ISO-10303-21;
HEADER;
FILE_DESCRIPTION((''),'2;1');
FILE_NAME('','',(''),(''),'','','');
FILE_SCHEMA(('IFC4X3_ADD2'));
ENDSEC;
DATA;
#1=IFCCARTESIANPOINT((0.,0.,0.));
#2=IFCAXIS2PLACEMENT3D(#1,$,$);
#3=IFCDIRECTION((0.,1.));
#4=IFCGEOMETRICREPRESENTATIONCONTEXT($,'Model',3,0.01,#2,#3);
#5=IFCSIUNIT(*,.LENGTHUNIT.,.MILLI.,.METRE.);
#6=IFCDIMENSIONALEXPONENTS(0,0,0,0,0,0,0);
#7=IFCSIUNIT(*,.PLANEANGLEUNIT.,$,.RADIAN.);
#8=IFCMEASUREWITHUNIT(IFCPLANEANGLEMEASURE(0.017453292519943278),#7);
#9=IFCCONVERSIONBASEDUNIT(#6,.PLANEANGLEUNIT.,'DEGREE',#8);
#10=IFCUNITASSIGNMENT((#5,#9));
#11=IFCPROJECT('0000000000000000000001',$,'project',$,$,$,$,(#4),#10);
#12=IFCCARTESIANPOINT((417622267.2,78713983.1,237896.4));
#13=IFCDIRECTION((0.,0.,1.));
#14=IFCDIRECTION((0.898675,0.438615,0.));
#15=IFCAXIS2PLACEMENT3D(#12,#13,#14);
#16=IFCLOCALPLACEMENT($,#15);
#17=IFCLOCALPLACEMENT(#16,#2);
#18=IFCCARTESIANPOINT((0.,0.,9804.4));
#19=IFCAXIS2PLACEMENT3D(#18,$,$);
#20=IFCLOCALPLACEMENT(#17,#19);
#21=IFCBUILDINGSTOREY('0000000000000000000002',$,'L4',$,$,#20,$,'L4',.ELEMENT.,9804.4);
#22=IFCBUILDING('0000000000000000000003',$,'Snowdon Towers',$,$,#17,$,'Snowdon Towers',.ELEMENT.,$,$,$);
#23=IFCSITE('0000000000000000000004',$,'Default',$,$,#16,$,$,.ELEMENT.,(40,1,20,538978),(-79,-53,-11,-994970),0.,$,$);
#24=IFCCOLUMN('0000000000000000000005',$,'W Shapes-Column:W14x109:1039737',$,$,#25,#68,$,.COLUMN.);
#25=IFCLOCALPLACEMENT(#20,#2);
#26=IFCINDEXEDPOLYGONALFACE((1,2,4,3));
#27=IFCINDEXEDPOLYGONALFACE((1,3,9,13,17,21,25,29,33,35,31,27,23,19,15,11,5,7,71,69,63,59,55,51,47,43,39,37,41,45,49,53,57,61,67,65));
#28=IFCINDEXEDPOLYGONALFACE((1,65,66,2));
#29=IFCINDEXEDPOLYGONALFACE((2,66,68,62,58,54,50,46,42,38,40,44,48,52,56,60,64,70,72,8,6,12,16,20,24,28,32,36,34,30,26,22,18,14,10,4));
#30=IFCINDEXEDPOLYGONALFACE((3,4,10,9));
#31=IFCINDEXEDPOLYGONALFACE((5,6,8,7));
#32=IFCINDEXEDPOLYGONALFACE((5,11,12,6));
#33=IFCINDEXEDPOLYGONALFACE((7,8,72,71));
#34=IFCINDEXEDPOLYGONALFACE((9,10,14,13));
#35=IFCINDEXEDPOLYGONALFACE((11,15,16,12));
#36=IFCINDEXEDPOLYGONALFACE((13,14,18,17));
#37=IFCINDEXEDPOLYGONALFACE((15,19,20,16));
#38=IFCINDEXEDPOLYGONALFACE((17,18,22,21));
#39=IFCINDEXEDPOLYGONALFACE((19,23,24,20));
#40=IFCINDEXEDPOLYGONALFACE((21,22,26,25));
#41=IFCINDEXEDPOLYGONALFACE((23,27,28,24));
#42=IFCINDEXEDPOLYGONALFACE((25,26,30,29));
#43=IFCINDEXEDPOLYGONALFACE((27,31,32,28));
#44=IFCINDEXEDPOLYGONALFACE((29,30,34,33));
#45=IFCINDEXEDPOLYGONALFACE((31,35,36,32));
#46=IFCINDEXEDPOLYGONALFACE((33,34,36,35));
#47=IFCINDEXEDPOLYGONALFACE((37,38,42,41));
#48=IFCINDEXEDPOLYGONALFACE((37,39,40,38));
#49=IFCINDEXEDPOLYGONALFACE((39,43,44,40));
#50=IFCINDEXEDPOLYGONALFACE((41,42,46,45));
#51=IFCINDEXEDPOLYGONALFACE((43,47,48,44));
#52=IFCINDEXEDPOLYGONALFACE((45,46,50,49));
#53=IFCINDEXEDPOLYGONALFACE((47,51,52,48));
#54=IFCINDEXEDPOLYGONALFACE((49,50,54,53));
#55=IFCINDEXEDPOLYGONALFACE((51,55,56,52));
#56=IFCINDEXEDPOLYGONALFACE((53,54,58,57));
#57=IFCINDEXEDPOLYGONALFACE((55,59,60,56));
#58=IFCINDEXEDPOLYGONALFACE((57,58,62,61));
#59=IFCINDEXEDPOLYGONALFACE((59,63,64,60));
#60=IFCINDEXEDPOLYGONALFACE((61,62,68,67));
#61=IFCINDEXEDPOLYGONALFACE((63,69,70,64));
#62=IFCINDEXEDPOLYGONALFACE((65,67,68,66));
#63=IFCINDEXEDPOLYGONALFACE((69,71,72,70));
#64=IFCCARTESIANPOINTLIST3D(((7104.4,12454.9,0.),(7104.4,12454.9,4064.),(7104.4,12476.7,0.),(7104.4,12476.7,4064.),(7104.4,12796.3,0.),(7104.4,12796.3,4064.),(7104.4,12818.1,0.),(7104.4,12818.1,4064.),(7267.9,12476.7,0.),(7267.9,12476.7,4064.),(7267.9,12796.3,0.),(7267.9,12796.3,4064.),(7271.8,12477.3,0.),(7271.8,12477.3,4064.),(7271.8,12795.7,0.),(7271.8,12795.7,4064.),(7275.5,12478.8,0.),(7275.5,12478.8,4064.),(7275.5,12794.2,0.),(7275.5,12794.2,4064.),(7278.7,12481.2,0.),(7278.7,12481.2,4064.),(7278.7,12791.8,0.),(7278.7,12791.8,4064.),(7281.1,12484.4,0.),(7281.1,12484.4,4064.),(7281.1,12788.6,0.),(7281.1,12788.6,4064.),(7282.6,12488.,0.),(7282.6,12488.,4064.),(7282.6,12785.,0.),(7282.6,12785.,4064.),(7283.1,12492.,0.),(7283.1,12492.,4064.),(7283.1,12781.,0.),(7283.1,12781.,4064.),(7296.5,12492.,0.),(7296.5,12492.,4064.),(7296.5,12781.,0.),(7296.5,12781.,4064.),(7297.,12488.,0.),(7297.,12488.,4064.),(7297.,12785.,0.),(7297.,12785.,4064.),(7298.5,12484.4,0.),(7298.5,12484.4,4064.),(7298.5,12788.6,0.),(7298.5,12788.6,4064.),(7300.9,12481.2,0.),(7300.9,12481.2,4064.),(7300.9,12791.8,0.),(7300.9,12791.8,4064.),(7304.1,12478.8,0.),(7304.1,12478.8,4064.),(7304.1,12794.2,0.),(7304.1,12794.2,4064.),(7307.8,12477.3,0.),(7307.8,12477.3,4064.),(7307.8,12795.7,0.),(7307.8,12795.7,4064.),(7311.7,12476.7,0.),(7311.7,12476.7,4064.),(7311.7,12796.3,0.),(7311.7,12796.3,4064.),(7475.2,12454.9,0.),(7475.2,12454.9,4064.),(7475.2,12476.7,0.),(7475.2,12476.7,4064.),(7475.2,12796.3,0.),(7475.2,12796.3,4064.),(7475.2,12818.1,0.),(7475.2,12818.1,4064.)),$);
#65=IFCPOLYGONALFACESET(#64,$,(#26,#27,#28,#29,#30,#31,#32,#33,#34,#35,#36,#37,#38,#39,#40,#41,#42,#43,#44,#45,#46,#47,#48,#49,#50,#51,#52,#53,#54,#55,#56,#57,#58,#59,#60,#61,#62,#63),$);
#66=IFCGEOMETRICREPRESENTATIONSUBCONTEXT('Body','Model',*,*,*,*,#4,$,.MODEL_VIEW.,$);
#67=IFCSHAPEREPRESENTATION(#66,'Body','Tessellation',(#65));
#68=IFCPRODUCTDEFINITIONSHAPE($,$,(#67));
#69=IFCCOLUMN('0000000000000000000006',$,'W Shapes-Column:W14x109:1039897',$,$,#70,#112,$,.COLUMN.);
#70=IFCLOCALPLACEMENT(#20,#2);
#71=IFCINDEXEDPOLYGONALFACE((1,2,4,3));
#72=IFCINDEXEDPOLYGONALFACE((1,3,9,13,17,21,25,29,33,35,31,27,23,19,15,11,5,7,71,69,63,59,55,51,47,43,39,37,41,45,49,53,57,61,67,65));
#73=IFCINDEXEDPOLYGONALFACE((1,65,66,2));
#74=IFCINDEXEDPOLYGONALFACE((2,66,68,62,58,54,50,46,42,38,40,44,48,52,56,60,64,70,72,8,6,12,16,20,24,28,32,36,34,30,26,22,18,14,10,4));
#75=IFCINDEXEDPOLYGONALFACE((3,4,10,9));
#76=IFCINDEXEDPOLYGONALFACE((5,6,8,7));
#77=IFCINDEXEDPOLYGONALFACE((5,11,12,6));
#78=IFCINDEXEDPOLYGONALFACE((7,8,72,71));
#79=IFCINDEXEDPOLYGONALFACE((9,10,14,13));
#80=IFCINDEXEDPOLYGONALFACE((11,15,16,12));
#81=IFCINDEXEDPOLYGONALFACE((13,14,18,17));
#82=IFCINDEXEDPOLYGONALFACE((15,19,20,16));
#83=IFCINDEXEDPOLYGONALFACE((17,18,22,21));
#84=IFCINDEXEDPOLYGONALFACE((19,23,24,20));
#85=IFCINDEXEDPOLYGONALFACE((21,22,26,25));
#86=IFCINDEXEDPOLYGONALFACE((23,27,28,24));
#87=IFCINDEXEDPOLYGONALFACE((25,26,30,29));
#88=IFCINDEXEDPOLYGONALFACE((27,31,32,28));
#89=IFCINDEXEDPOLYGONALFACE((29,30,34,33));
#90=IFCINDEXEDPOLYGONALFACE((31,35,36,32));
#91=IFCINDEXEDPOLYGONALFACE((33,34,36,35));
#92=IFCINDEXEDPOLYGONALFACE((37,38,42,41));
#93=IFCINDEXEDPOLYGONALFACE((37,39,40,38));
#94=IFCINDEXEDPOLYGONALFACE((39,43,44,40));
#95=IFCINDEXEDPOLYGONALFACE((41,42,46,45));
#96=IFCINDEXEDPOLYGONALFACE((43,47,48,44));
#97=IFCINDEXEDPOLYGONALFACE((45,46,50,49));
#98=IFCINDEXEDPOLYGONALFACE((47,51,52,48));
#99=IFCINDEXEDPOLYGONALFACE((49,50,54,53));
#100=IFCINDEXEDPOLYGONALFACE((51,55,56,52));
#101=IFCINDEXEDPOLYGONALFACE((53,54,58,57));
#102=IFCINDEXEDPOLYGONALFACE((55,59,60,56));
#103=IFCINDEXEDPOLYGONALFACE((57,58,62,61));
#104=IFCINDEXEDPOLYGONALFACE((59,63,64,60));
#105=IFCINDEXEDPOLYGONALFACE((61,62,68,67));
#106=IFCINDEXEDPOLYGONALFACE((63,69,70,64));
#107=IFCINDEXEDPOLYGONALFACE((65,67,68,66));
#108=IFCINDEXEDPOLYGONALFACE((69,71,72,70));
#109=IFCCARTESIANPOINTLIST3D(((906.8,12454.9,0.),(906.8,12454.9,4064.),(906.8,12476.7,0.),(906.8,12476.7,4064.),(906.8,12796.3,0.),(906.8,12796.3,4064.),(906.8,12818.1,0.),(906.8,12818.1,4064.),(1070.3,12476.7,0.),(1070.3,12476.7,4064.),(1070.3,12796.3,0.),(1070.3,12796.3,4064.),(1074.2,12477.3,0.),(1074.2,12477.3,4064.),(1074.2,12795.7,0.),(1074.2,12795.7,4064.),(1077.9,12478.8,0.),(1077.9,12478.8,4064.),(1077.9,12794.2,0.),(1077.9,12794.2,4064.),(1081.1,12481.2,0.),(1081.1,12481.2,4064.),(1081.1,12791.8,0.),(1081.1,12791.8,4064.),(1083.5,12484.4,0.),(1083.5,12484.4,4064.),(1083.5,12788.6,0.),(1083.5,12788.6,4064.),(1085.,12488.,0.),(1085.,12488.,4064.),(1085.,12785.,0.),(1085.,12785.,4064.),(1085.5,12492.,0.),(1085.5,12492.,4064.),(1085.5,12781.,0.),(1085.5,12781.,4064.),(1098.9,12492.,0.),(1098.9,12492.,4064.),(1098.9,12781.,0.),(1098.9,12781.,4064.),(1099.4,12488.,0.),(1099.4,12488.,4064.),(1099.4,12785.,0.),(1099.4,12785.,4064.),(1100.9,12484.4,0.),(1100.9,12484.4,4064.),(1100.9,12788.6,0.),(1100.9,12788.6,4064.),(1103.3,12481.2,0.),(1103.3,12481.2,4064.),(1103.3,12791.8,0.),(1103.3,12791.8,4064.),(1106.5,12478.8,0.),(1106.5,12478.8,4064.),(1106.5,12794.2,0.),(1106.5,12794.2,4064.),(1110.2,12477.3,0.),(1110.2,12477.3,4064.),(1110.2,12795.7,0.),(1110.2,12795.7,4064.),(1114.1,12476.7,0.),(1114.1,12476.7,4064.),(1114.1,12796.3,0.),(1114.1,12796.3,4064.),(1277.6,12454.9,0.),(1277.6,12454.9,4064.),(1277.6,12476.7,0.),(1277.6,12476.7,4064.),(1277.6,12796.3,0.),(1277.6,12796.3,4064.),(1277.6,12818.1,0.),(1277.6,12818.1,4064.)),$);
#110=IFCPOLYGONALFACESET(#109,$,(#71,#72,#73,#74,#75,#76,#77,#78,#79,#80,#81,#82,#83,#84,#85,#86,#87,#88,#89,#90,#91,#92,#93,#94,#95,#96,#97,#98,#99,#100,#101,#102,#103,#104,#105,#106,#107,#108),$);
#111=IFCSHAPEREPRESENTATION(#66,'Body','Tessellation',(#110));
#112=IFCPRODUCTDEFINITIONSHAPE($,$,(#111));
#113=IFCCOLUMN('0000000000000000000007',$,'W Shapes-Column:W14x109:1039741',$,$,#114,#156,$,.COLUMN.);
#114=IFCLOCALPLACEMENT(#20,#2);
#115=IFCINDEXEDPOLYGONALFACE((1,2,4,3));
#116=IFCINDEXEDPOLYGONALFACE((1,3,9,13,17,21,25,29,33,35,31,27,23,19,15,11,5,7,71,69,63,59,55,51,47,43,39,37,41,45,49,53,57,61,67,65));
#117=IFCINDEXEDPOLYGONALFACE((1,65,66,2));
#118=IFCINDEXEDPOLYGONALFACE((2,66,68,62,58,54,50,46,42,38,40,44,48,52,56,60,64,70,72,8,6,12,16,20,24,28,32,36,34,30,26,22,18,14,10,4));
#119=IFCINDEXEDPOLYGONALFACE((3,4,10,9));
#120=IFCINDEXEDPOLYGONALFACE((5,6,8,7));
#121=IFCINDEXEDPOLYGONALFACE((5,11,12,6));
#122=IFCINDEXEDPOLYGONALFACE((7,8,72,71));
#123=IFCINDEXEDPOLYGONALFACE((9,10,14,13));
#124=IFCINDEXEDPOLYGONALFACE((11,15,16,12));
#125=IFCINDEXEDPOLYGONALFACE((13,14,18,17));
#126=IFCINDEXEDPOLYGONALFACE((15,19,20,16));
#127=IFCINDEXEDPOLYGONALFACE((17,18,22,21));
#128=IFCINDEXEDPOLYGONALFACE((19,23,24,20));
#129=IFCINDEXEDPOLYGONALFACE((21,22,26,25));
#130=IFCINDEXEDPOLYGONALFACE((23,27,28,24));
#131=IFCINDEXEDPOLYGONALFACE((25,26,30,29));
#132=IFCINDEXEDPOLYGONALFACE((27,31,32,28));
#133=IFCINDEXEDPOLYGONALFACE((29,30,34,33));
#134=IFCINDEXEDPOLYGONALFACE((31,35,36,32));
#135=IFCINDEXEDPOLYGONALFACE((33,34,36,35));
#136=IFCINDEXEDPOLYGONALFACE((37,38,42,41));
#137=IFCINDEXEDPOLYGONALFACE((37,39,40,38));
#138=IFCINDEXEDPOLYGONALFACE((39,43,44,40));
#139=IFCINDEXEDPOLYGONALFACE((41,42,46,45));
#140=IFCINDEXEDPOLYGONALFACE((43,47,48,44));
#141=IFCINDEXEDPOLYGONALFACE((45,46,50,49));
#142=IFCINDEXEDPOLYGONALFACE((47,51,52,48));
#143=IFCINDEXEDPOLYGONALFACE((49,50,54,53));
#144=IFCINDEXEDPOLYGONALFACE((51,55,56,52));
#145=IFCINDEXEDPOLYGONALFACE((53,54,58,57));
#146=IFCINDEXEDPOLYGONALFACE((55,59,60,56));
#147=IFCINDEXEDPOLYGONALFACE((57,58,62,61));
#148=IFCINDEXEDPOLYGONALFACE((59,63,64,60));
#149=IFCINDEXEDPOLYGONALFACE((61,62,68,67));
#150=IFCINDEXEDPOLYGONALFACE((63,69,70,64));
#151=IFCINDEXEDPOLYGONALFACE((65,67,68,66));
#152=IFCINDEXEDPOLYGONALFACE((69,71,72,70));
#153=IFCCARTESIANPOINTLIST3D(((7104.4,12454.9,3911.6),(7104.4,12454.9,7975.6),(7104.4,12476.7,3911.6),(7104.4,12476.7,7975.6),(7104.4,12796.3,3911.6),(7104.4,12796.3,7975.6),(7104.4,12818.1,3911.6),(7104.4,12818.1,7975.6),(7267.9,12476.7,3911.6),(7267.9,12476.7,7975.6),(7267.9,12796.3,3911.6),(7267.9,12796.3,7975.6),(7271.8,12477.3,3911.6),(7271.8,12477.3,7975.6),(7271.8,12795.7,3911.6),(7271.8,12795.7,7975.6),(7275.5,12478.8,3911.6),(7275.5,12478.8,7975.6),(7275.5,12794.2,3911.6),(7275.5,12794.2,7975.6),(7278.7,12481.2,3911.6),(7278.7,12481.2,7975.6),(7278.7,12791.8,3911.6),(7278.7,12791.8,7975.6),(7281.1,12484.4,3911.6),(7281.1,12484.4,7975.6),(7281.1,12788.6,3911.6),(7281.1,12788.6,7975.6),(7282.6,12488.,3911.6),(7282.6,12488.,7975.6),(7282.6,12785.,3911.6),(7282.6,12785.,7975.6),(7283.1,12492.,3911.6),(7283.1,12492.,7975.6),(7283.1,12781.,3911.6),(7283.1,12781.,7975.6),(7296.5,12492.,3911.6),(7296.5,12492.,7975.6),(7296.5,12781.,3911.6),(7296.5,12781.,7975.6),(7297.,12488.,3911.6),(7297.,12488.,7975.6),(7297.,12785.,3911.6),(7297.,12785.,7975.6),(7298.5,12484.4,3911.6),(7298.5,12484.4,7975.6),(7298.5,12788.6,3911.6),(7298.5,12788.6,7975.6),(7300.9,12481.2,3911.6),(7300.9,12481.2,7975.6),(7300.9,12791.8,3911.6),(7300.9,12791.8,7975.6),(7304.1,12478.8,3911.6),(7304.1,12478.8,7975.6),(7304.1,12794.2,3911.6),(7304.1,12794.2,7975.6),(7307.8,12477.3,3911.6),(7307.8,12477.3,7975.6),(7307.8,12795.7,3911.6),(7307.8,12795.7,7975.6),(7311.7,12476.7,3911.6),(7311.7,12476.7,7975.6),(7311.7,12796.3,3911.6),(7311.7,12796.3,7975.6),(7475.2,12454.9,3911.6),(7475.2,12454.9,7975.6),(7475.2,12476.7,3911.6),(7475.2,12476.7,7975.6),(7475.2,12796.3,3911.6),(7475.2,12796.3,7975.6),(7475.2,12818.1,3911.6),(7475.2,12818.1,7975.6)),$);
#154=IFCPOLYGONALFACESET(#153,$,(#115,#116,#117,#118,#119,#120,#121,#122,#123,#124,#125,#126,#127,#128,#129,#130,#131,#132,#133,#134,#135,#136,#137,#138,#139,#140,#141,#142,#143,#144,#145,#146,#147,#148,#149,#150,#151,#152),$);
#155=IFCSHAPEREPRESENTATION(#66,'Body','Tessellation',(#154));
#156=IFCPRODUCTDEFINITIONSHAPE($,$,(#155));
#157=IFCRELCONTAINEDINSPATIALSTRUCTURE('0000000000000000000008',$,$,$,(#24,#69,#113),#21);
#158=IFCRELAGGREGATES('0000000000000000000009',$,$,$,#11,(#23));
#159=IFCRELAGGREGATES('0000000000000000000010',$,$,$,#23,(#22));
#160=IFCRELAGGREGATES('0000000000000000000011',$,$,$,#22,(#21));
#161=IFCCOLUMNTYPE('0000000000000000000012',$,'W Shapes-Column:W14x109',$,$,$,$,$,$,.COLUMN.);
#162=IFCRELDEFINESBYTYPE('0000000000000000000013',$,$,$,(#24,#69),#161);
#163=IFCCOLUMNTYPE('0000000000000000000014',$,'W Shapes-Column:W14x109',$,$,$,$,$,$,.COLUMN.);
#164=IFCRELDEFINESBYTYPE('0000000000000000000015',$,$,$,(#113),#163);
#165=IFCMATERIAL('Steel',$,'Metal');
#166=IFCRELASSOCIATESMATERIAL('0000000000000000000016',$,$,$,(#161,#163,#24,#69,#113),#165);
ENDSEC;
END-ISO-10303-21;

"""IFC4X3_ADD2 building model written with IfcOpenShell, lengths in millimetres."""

from ifc_helpers import new_model, entity, si_unit, converted_unit, direction, frame, frame_2d, origin, place, context, subcontext, project, spatial, i_section, extrude, source, transform, mapped, material, material_profile, profile_set, profile_usage, type_object, type_shapes, element, save


model = new_model("IFC4X3_ADD2")

# Units and contexts
model_context = context("Model", 3, precision=0.01, world=origin(), true_north=direction((0.0, 1.0)))
body_context = subcontext(model_context, "Body", "Model", "MODEL_VIEW")
ifc_project = project(units=[si_unit("LENGTHUNIT", "METRE", prefix="MILLI"), converted_unit("PLANEANGLEUNIT", "DEGREE", entity("IfcPlaneAngleMeasure", 0.017453292519943278), si_unit("PLANEANGLEUNIT", "RADIAN"), dimensions=[0, 0, 0, 0, 0, 0, 0])], contexts=[model_context])

# Site, building, storey
site_placement = place(None, frame((417622267.2, 78713983.1, 237896.4), z_axis=(0.0, 0.0, 1.0), x_axis=(0.898675, 0.438615, 0.0)))
site = spatial("IfcSite", under=ifc_project, at=site_placement, Name="Default", CompositionType="ELEMENT", RefLatitude=(40, 1, 20, 538978), RefLongitude=(-79, -53, -11, -994970), RefElevation=0.0)
building_placement = place(site_placement, origin())
building = spatial("IfcBuilding", under=site, at=building_placement, Name="Snowdon Towers", LongName="Snowdon Towers", CompositionType="ELEMENT")
storey_placement = place(building_placement, frame((0.0, 0.0, 9804.4)))
storey = spatial("IfcBuildingStorey", under=building, at=storey_placement, Name="L4", LongName="L4", CompositionType="ELEMENT", Elevation=9804.4)

# Columns
ifc_material_1 = material(Name="Steel", Category="Metal")
ifc_material_profile_1 = material_profile(ifc_material_1, i_section(OverallWidth=370.8, OverallDepth=363.2, WebThickness=13.3, FlangeThickness=21.8, FilletRadius=15.2, at=frame_2d((0.0, 0.0), x_axis=(1.0, 0.0))), Name="W14x109")
ifc_profile_set_1 = profile_set([ifc_material_profile_1], Name="W14x109")
ifc_profile_usage_1 = profile_usage(ifc_profile_set_1)
column_type_1 = type_object("IfcColumnType", Name="W Shapes-Column:W14x109", PredefinedType="COLUMN", material=ifc_profile_set_1)
shared_shape_1 = source(origin(), body_context, "Body", "SweptSolid", [
    extrude(i_section(OverallWidth=370.8, OverallDepth=363.2, WebThickness=13.3, FlangeThickness=21.8, FilletRadius=15.2, at=frame_2d((0.0, 0.0), x_axis=(1.0, 0.0))), frame((0.0, 0.0, 9804.4), z_axis=(0.0, 0.0, 1.0), x_axis=(-1.0, 0.0, 0.0)), (0.0, 0.0, 1.0), 4064.0),
])
type_shapes(column_type_1, [shared_shape_1])
column_1_placement = place(storey_placement, frame((7289.8, 12636.5, -9804.4)))
element("IfcColumn", 1, at=column_1_placement, inside=storey, type_object=column_type_1, material=ifc_profile_usage_1, Name="W Shapes-Column:W14x109:1039737", PredefinedType="COLUMN", context=body_context, shape_type="MappedRepresentation", body=[
    mapped(shared_shape_1, transform((0.0, 0.0, 0.0), scale=1.0)),
])
column_2_placement = place(storey_placement, frame((1092.2, 12636.5, -9804.4), z_axis=(0.0, 0.0, 1.0), x_axis=(-1.0, 0.0, 0.0)))
element("IfcColumn", 2, at=column_2_placement, inside=storey, type_object=column_type_1, material=ifc_profile_usage_1, Name="W Shapes-Column:W14x109:1039897", PredefinedType="COLUMN", context=body_context, shape_type="MappedRepresentation", body=[
    mapped(shared_shape_1, transform((0.0, 0.0, 0.0), scale=1.0)),
])
column_type_2 = type_object("IfcColumnType", Name="W Shapes-Column:W14x109", PredefinedType="COLUMN", material=ifc_profile_set_1)
shared_shape_2 = source(origin(), body_context, "Body", "SweptSolid", [
    extrude(i_section(OverallWidth=370.8, OverallDepth=363.2, WebThickness=13.3, FlangeThickness=21.8, FilletRadius=15.2, at=frame_2d((0.0, 0.0), x_axis=(1.0, 0.0))), frame((0.0, 0.0, 13716.0), z_axis=(0.0, 0.0, 1.0), x_axis=(-1.0, 0.0, 0.0)), (0.0, 0.0, 1.0), 4064.0),
])
type_shapes(column_type_2, [shared_shape_2])
column_3_placement = place(storey_placement, frame((7289.8, 12636.5, -9804.4)))
element("IfcColumn", 3, at=column_3_placement, inside=storey, type_object=column_type_2, material=ifc_profile_usage_1, Name="W Shapes-Column:W14x109:1039741", PredefinedType="COLUMN", context=body_context, shape_type="MappedRepresentation", body=[
    mapped(shared_shape_2, transform((0.0, 0.0, 0.0), scale=1.0)),
])

save(model, "model.ifc")
